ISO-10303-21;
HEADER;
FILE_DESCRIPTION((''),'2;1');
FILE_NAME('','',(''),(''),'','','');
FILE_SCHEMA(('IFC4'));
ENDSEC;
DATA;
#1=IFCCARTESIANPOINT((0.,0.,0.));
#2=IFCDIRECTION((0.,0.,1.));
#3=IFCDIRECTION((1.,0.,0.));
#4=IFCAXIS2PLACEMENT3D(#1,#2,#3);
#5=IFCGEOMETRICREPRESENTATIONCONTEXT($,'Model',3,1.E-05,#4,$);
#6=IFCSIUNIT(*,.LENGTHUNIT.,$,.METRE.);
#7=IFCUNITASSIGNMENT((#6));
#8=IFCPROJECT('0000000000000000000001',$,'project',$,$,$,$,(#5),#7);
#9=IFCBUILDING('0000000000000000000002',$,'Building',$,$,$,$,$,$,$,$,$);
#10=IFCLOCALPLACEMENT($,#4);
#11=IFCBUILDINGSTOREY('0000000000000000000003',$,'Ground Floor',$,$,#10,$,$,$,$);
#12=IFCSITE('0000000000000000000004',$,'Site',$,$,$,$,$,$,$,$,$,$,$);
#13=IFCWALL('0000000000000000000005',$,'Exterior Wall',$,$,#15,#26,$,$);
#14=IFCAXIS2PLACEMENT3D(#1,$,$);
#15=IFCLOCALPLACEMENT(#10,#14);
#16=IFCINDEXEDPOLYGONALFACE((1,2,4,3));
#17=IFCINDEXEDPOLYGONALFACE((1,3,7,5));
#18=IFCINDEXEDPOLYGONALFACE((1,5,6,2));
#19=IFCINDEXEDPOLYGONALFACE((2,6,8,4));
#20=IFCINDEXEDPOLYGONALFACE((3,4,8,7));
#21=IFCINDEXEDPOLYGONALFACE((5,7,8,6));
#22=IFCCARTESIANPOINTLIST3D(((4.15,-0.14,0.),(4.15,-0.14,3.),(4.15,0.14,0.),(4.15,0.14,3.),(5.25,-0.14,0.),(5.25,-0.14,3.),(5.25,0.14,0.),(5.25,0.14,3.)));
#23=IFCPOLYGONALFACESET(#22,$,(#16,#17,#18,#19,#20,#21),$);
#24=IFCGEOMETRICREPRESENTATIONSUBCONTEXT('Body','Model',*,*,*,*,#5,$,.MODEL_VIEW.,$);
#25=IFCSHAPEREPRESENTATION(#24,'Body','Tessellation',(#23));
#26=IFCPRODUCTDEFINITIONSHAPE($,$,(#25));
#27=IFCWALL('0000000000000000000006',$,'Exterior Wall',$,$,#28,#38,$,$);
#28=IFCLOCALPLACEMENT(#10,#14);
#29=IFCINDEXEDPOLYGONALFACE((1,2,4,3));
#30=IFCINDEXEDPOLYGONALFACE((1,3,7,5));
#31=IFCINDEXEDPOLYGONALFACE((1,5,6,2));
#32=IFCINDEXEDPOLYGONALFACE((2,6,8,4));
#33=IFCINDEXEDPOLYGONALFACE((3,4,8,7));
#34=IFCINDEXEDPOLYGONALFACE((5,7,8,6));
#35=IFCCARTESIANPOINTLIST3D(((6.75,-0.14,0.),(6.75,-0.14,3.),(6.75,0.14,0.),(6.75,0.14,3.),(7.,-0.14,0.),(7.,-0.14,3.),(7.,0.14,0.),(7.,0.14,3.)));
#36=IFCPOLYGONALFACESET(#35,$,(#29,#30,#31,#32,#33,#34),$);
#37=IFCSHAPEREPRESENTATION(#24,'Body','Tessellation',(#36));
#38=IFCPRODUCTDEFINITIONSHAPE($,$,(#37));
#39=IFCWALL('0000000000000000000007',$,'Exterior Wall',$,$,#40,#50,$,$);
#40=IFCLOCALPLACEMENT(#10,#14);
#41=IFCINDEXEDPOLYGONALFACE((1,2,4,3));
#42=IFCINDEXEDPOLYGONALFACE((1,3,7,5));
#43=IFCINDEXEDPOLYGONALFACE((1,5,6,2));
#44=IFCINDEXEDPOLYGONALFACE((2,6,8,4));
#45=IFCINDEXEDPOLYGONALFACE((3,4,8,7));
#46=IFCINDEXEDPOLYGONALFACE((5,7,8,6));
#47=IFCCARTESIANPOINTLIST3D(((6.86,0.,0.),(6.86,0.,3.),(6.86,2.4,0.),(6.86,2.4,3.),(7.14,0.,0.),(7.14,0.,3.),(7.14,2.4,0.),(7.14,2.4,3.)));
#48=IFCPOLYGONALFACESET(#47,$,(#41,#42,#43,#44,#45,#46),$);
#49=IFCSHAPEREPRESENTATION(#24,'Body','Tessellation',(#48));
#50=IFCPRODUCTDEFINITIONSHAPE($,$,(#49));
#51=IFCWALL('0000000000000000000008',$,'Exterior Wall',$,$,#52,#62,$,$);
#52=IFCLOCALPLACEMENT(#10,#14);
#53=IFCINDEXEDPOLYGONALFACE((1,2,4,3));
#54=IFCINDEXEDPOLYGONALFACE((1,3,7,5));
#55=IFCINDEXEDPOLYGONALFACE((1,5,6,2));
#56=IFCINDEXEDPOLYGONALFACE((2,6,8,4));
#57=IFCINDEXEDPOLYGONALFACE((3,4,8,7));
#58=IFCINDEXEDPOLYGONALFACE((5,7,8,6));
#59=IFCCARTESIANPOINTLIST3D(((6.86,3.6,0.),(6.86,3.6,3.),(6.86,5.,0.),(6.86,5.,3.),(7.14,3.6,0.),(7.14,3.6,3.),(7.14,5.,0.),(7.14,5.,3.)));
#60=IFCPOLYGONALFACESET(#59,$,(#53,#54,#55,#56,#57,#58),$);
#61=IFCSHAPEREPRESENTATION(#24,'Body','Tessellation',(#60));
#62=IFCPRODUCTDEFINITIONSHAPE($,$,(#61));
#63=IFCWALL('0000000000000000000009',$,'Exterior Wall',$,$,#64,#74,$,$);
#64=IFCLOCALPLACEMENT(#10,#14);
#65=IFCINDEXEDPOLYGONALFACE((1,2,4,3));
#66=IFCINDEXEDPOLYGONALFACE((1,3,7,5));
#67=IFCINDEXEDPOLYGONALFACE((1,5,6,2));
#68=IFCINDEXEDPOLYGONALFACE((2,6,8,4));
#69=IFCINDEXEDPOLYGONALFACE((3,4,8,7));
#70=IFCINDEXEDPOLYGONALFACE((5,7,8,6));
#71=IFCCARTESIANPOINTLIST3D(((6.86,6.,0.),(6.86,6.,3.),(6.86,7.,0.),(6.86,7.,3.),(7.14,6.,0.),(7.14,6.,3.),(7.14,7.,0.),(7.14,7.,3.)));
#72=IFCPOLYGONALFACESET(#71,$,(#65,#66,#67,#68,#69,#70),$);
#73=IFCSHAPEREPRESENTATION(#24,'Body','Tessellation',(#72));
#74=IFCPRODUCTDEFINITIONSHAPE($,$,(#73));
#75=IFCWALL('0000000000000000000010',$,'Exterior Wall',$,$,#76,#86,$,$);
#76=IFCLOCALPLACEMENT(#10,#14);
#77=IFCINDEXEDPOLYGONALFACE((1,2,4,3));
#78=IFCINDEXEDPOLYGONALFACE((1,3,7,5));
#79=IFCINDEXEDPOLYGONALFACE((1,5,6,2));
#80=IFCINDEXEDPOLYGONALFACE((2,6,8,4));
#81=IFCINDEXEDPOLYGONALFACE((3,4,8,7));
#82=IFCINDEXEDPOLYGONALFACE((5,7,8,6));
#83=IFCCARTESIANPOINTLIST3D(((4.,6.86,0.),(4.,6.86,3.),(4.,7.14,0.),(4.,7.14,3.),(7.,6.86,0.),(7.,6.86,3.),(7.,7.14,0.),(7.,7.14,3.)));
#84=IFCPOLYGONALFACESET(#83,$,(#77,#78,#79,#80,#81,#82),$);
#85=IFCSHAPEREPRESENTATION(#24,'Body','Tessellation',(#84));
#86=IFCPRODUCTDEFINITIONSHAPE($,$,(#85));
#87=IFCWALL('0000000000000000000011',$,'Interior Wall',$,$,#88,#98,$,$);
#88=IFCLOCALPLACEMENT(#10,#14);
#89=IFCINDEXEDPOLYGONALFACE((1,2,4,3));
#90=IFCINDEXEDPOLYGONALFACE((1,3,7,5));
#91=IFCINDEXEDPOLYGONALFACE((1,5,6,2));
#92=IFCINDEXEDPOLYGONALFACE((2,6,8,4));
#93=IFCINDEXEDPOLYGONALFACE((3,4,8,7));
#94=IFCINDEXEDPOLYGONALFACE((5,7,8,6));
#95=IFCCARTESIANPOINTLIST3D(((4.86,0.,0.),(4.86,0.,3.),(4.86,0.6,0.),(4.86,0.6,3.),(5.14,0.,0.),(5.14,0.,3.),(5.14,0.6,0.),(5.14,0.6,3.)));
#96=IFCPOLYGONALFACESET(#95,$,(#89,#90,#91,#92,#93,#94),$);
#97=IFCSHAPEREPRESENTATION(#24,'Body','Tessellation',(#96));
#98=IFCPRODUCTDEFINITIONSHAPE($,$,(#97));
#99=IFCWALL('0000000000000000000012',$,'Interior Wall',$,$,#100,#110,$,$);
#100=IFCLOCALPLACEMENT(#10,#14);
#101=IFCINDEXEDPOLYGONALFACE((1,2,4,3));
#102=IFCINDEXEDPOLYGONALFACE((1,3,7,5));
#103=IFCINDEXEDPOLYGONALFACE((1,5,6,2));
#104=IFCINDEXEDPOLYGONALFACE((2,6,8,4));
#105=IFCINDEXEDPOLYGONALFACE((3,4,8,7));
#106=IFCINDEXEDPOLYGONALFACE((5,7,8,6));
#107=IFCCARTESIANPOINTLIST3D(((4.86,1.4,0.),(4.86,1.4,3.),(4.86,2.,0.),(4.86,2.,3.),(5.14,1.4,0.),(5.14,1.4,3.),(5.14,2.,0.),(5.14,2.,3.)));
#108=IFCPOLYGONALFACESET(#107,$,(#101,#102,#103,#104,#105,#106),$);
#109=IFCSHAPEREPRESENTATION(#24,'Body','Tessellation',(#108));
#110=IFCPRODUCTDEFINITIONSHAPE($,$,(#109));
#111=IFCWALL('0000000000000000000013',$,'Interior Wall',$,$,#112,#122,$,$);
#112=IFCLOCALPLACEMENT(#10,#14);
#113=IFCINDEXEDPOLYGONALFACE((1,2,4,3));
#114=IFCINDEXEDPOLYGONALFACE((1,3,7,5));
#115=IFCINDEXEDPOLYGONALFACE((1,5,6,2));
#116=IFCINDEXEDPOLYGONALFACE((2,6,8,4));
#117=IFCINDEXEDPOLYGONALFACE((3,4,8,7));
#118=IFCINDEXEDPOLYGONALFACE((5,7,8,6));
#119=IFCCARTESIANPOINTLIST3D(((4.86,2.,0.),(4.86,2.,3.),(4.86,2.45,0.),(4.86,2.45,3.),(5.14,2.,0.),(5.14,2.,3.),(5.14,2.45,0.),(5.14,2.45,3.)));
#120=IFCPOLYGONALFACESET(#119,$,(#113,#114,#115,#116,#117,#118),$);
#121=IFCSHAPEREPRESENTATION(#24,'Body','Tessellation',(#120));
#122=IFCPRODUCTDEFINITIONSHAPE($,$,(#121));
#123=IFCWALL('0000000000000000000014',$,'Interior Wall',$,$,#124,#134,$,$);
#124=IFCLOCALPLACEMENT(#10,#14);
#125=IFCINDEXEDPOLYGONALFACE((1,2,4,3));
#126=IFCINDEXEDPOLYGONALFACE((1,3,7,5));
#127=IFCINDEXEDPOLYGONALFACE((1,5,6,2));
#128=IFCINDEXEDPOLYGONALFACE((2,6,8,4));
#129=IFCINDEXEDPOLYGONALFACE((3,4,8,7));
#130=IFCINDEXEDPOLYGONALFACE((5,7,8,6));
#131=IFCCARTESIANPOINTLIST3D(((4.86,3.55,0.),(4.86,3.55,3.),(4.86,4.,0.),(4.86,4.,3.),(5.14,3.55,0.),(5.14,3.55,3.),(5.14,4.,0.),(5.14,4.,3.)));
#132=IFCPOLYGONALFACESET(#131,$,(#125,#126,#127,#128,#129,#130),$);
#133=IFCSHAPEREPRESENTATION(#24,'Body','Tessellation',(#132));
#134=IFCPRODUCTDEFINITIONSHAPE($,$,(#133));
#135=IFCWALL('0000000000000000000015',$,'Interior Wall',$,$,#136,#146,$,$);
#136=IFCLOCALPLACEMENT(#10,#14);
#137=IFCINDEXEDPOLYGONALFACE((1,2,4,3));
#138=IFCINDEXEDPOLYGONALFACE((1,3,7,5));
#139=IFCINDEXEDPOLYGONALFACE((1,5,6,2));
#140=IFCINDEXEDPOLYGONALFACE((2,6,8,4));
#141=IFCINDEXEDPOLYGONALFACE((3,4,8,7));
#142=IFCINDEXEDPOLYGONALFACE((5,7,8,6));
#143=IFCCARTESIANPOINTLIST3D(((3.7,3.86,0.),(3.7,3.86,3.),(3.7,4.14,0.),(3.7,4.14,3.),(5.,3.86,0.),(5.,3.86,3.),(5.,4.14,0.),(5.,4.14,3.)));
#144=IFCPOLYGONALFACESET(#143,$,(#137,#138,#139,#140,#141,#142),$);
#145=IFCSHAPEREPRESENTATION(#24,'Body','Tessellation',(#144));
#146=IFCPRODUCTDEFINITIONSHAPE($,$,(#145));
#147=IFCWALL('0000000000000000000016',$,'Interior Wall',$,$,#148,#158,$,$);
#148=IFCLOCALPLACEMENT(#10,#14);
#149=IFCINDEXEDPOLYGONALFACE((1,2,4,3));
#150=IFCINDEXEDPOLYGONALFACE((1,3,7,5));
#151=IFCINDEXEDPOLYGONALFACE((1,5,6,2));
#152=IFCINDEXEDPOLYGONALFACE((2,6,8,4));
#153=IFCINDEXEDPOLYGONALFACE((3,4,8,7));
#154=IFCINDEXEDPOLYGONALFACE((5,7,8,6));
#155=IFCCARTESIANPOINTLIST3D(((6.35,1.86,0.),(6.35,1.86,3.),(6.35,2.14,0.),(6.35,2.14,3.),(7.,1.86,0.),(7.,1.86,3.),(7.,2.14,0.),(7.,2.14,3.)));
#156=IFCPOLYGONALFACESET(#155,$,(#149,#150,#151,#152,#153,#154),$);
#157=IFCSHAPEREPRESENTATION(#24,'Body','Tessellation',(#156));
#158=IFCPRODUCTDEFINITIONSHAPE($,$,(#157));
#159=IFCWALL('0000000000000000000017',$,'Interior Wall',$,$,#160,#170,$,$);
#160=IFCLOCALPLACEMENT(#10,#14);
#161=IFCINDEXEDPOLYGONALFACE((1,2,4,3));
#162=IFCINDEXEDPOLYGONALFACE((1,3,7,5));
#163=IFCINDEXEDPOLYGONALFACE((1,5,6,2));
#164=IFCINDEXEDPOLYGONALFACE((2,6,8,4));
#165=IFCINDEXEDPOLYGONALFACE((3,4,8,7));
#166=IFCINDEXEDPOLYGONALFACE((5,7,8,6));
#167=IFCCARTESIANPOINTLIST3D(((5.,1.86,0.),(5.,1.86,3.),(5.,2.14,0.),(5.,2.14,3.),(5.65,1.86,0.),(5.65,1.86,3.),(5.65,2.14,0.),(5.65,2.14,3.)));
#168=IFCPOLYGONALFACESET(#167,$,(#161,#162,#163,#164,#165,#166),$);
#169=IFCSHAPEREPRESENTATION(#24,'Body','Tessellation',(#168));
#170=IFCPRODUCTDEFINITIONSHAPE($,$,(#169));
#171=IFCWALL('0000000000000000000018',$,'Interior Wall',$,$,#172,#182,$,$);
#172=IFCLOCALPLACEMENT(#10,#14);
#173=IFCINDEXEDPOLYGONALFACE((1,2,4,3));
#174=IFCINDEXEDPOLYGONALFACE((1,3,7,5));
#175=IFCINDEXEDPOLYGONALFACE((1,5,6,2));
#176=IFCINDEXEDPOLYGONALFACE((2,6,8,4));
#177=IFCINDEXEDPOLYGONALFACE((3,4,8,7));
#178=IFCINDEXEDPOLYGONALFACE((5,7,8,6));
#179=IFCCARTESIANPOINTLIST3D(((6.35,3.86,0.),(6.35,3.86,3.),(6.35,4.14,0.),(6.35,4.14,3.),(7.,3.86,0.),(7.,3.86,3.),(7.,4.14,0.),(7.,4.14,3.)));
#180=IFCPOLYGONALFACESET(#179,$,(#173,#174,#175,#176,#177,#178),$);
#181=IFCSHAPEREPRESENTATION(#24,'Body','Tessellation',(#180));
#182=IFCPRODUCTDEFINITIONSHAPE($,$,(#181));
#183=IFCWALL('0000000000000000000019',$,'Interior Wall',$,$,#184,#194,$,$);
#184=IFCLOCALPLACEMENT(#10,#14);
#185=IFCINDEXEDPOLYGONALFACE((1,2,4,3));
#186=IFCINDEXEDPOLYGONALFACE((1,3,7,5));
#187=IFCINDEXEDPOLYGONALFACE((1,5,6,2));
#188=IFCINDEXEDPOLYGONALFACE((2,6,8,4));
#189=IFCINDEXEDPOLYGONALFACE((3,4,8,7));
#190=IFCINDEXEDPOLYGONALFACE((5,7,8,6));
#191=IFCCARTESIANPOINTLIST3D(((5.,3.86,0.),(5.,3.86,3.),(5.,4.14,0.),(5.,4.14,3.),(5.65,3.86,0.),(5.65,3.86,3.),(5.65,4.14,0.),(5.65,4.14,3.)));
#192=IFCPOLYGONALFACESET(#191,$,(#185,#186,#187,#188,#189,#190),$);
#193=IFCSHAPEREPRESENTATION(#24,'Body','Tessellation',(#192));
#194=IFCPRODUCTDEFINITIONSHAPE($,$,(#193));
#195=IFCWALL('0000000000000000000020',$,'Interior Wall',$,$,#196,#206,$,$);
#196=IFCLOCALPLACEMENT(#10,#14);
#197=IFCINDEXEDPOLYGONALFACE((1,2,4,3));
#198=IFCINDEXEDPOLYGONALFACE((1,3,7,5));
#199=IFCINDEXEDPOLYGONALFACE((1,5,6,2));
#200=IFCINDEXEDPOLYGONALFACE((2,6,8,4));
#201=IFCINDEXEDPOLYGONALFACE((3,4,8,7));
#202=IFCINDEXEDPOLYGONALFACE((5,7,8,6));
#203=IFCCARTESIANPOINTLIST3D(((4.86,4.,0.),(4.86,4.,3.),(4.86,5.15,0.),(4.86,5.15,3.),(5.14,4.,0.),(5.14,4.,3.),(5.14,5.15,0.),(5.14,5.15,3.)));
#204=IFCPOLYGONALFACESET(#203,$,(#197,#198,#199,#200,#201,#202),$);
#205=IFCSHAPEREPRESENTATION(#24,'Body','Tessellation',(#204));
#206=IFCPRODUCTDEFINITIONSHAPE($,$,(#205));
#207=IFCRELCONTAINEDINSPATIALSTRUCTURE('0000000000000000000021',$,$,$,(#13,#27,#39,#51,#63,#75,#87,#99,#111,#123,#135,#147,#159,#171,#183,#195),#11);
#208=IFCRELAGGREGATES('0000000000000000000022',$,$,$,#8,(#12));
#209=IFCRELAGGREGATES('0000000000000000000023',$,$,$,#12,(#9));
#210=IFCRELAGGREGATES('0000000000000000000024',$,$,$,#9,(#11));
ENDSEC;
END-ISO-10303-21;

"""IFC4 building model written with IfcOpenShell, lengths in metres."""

from ifc_helpers import new_model, si_unit, frame, origin_with_axes, place, context, subcontext, project, spatial, indexed_curve, outline, extrude, element, save


model = new_model("IFC4")

# Units and contexts
model_context = context("Model", 3, precision=1e-05, world=origin_with_axes())
body_context = subcontext(model_context, "Body", "Model", "MODEL_VIEW")
ifc_project = project(units=[si_unit("LENGTHUNIT", "METRE")], contexts=[model_context])

# Site, building, storey
site = spatial("IfcSite", under=ifc_project, Name="Site")
building = spatial("IfcBuilding", under=site, Name="Building")
storey_placement = place(None, origin_with_axes())
storey = spatial("IfcBuildingStorey", under=building, at=storey_placement, Name="Ground Floor")

# Walls
wall_1_placement = place(storey_placement, frame((4.15, 0.0, 0.0), z_axis=(0.0, 0.0, 1.0), x_axis=(1.0, 0.0, 0.0)))
element("IfcWall", 1, at=wall_1_placement, inside=storey, Name="Exterior Wall", context=body_context, shape_type="SweptSolid", body=[
    extrude(outline(indexed_curve([(0.0, 0.0), (0.0, 0.28), (1.1, 0.28), (1.1, 0.0), (0.0, 0.0)], self_intersect=False)), frame((0.0, -0.14, 0.0), z_axis=(0.0, 0.0, 1.0), x_axis=(1.0, 0.0, 0.0)), (0.0, 0.0, 1.0), 3.0),
])
wall_2_placement = place(storey_placement, frame((6.75, 0.0, 0.0), z_axis=(0.0, 0.0, 1.0), x_axis=(1.0, 0.0, 0.0)))
element("IfcWall", 2, at=wall_2_placement, inside=storey, Name="Exterior Wall", context=body_context, shape_type="SweptSolid", body=[
    extrude(outline(indexed_curve([(0.0, 0.0), (0.0, 0.28), (0.25, 0.28), (0.25, 0.0), (0.0, 0.0)], self_intersect=False)), frame((0.0, -0.14, 0.0), z_axis=(0.0, 0.0, 1.0), x_axis=(1.0, 0.0, 0.0)), (0.0, 0.0, 1.0), 3.0),
])
wall_3_placement = place(storey_placement, frame((7.0, 0.0, 0.0), z_axis=(0.0, 0.0, 1.0), x_axis=(0.0, 1.0, 0.0)))
element("IfcWall", 3, at=wall_3_placement, inside=storey, Name="Exterior Wall", context=body_context, shape_type="SweptSolid", body=[
    extrude(outline(indexed_curve([(0.0, 0.0), (0.0, 0.28), (2.4, 0.28), (2.4, 0.0), (0.0, 0.0)], self_intersect=False)), frame((0.0, -0.14, 0.0), z_axis=(0.0, 0.0, 1.0), x_axis=(1.0, 0.0, 0.0)), (0.0, 0.0, 1.0), 3.0),
])
wall_4_placement = place(storey_placement, frame((7.0, 3.6, 0.0), z_axis=(0.0, 0.0, 1.0), x_axis=(0.0, 1.0, 0.0)))
element("IfcWall", 4, at=wall_4_placement, inside=storey, Name="Exterior Wall", context=body_context, shape_type="SweptSolid", body=[
    extrude(outline(indexed_curve([(0.0, 0.0), (0.0, 0.28), (1.4, 0.28), (1.4, 0.0), (0.0, 0.0)], self_intersect=False)), frame((0.0, -0.14, 0.0), z_axis=(0.0, 0.0, 1.0), x_axis=(1.0, 0.0, 0.0)), (0.0, 0.0, 1.0), 3.0),
])
wall_5_placement = place(storey_placement, frame((7.0, 6.0, 0.0), z_axis=(0.0, 0.0, 1.0), x_axis=(0.0, 1.0, 0.0)))
element("IfcWall", 5, at=wall_5_placement, inside=storey, Name="Exterior Wall", context=body_context, shape_type="SweptSolid", body=[
    extrude(outline(indexed_curve([(0.0, 0.0), (0.0, 0.28), (1.0, 0.28), (1.0, 0.0), (0.0, 0.0)], self_intersect=False)), frame((0.0, -0.14, 0.0), z_axis=(0.0, 0.0, 1.0), x_axis=(1.0, 0.0, 0.0)), (0.0, 0.0, 1.0), 3.0),
])
wall_6_placement = place(storey_placement, frame((7.0, 7.0, 0.0), z_axis=(0.0, 0.0, 1.0), x_axis=(-1.0, 0.0, 0.0)))
element("IfcWall", 6, at=wall_6_placement, inside=storey, Name="Exterior Wall", context=body_context, shape_type="SweptSolid", body=[
    extrude(outline(indexed_curve([(0.0, 0.0), (0.0, 0.28), (3.0, 0.28), (3.0, 0.0), (0.0, 0.0)], self_intersect=False)), frame((0.0, -0.14, 0.0), z_axis=(0.0, 0.0, 1.0), x_axis=(1.0, 0.0, 0.0)), (0.0, 0.0, 1.0), 3.0),
])
wall_7_placement = place(storey_placement, frame((5.0, 0.0, 0.0), z_axis=(0.0, 0.0, 1.0), x_axis=(0.0, 1.0, 0.0)))
element("IfcWall", 7, at=wall_7_placement, inside=storey, Name="Interior Wall", context=body_context, shape_type="SweptSolid", body=[
    extrude(outline(indexed_curve([(0.0, 0.0), (0.0, 0.28), (0.6, 0.28), (0.6, 0.0), (0.0, 0.0)], self_intersect=False)), frame((0.0, -0.14, 0.0), z_axis=(0.0, 0.0, 1.0), x_axis=(1.0, 0.0, 0.0)), (0.0, 0.0, 1.0), 3.0),
])
wall_8_placement = place(storey_placement, frame((5.0, 1.4, 0.0), z_axis=(0.0, 0.0, 1.0), x_axis=(0.0, 1.0, 0.0)))
element("IfcWall", 8, at=wall_8_placement, inside=storey, Name="Interior Wall", context=body_context, shape_type="SweptSolid", body=[
    extrude(outline(indexed_curve([(0.0, 0.0), (0.0, 0.28), (0.6, 0.28), (0.6, 0.0), (0.0, 0.0)], self_intersect=False)), frame((0.0, -0.14, 0.0), z_axis=(0.0, 0.0, 1.0), x_axis=(1.0, 0.0, 0.0)), (0.0, 0.0, 1.0), 3.0),
])
for number, where, z_axis, x_axis, name in (
    (9, (5.0, 2.0, 0.0), (0.0, 0.0, 1.0), (0.0, 1.0, 0.0), "Interior Wall"),
    (10, (5.0, 3.55, 0.0), (0.0, 0.0, 1.0), (0.0, 1.0, 0.0), "Interior Wall"),
):
    element("IfcWall", number, at=place(storey_placement, frame(where, z_axis=z_axis, x_axis=x_axis)), inside=storey, Name=name, context=body_context, shape_type="SweptSolid", body=[
        extrude(outline(indexed_curve([(0.0, 0.0), (0.0, 0.28), (0.45, 0.28), (0.45, 0.0), (0.0, 0.0)], self_intersect=False)), frame((0.0, -0.14, 0.0), z_axis=(0.0, 0.0, 1.0), x_axis=(1.0, 0.0, 0.0)), (0.0, 0.0, 1.0), 3.0),
    ])
wall_9_placement = place(storey_placement, frame((5.0, 4.0, 0.0), z_axis=(0.0, 0.0, 1.0), x_axis=(-1.0, 0.0, 0.0)))
element("IfcWall", 11, at=wall_9_placement, inside=storey, Name="Interior Wall", context=body_context, shape_type="SweptSolid", body=[
    extrude(outline(indexed_curve([(0.0, 0.0), (0.0, 0.28), (1.3, 0.28), (1.3, 0.0), (0.0, 0.0)], self_intersect=False)), frame((0.0, -0.14, 0.0), z_axis=(0.0, 0.0, 1.0), x_axis=(1.0, 0.0, 0.0)), (0.0, 0.0, 1.0), 3.0),
])
for number, where, z_axis, x_axis, name in (
    (12, (7.0, 2.0, 0.0), (0.0, 0.0, 1.0), (-1.0, 0.0, 0.0), "Interior Wall"),
    (13, (5.65, 2.0, 0.0), (0.0, 0.0, 1.0), (-1.0, 0.0, 0.0), "Interior Wall"),
    (14, (7.0, 4.0, 0.0), (0.0, 0.0, 1.0), (-1.0, 0.0, 0.0), "Interior Wall"),
    (15, (5.65, 4.0, 0.0), (0.0, 0.0, 1.0), (-1.0, 0.0, 0.0), "Interior Wall"),
):
    element("IfcWall", number, at=place(storey_placement, frame(where, z_axis=z_axis, x_axis=x_axis)), inside=storey, Name=name, context=body_context, shape_type="SweptSolid", body=[
        extrude(outline(indexed_curve([(0.0, 0.0), (0.0, 0.28), (0.65, 0.28), (0.65, 0.0), (0.0, 0.0)], self_intersect=False)), frame((0.0, -0.14, 0.0), z_axis=(0.0, 0.0, 1.0), x_axis=(1.0, 0.0, 0.0)), (0.0, 0.0, 1.0), 3.0),
    ])
for number, where, z_axis, x_axis, name in (
    (16, (5.0, 4.0, 0.0), (0.0, 0.0, 1.0), (0.0, 1.0, 0.0), "Interior Wall"),
):
    element("IfcWall", number, at=place(storey_placement, frame(where, z_axis=z_axis, x_axis=x_axis)), inside=storey, Name=name, context=body_context, shape_type="SweptSolid", body=[
        extrude(outline(indexed_curve([(0.0, 0.0), (0.0, 0.28), (1.15, 0.28), (1.15, 0.0), (0.0, 0.0)], self_intersect=False)), frame((0.0, -0.14, 0.0), z_axis=(0.0, 0.0, 1.0), x_axis=(1.0, 0.0, 0.0)), (0.0, 0.0, 1.0), 3.0),
    ])

save(model, "model.ifc")
